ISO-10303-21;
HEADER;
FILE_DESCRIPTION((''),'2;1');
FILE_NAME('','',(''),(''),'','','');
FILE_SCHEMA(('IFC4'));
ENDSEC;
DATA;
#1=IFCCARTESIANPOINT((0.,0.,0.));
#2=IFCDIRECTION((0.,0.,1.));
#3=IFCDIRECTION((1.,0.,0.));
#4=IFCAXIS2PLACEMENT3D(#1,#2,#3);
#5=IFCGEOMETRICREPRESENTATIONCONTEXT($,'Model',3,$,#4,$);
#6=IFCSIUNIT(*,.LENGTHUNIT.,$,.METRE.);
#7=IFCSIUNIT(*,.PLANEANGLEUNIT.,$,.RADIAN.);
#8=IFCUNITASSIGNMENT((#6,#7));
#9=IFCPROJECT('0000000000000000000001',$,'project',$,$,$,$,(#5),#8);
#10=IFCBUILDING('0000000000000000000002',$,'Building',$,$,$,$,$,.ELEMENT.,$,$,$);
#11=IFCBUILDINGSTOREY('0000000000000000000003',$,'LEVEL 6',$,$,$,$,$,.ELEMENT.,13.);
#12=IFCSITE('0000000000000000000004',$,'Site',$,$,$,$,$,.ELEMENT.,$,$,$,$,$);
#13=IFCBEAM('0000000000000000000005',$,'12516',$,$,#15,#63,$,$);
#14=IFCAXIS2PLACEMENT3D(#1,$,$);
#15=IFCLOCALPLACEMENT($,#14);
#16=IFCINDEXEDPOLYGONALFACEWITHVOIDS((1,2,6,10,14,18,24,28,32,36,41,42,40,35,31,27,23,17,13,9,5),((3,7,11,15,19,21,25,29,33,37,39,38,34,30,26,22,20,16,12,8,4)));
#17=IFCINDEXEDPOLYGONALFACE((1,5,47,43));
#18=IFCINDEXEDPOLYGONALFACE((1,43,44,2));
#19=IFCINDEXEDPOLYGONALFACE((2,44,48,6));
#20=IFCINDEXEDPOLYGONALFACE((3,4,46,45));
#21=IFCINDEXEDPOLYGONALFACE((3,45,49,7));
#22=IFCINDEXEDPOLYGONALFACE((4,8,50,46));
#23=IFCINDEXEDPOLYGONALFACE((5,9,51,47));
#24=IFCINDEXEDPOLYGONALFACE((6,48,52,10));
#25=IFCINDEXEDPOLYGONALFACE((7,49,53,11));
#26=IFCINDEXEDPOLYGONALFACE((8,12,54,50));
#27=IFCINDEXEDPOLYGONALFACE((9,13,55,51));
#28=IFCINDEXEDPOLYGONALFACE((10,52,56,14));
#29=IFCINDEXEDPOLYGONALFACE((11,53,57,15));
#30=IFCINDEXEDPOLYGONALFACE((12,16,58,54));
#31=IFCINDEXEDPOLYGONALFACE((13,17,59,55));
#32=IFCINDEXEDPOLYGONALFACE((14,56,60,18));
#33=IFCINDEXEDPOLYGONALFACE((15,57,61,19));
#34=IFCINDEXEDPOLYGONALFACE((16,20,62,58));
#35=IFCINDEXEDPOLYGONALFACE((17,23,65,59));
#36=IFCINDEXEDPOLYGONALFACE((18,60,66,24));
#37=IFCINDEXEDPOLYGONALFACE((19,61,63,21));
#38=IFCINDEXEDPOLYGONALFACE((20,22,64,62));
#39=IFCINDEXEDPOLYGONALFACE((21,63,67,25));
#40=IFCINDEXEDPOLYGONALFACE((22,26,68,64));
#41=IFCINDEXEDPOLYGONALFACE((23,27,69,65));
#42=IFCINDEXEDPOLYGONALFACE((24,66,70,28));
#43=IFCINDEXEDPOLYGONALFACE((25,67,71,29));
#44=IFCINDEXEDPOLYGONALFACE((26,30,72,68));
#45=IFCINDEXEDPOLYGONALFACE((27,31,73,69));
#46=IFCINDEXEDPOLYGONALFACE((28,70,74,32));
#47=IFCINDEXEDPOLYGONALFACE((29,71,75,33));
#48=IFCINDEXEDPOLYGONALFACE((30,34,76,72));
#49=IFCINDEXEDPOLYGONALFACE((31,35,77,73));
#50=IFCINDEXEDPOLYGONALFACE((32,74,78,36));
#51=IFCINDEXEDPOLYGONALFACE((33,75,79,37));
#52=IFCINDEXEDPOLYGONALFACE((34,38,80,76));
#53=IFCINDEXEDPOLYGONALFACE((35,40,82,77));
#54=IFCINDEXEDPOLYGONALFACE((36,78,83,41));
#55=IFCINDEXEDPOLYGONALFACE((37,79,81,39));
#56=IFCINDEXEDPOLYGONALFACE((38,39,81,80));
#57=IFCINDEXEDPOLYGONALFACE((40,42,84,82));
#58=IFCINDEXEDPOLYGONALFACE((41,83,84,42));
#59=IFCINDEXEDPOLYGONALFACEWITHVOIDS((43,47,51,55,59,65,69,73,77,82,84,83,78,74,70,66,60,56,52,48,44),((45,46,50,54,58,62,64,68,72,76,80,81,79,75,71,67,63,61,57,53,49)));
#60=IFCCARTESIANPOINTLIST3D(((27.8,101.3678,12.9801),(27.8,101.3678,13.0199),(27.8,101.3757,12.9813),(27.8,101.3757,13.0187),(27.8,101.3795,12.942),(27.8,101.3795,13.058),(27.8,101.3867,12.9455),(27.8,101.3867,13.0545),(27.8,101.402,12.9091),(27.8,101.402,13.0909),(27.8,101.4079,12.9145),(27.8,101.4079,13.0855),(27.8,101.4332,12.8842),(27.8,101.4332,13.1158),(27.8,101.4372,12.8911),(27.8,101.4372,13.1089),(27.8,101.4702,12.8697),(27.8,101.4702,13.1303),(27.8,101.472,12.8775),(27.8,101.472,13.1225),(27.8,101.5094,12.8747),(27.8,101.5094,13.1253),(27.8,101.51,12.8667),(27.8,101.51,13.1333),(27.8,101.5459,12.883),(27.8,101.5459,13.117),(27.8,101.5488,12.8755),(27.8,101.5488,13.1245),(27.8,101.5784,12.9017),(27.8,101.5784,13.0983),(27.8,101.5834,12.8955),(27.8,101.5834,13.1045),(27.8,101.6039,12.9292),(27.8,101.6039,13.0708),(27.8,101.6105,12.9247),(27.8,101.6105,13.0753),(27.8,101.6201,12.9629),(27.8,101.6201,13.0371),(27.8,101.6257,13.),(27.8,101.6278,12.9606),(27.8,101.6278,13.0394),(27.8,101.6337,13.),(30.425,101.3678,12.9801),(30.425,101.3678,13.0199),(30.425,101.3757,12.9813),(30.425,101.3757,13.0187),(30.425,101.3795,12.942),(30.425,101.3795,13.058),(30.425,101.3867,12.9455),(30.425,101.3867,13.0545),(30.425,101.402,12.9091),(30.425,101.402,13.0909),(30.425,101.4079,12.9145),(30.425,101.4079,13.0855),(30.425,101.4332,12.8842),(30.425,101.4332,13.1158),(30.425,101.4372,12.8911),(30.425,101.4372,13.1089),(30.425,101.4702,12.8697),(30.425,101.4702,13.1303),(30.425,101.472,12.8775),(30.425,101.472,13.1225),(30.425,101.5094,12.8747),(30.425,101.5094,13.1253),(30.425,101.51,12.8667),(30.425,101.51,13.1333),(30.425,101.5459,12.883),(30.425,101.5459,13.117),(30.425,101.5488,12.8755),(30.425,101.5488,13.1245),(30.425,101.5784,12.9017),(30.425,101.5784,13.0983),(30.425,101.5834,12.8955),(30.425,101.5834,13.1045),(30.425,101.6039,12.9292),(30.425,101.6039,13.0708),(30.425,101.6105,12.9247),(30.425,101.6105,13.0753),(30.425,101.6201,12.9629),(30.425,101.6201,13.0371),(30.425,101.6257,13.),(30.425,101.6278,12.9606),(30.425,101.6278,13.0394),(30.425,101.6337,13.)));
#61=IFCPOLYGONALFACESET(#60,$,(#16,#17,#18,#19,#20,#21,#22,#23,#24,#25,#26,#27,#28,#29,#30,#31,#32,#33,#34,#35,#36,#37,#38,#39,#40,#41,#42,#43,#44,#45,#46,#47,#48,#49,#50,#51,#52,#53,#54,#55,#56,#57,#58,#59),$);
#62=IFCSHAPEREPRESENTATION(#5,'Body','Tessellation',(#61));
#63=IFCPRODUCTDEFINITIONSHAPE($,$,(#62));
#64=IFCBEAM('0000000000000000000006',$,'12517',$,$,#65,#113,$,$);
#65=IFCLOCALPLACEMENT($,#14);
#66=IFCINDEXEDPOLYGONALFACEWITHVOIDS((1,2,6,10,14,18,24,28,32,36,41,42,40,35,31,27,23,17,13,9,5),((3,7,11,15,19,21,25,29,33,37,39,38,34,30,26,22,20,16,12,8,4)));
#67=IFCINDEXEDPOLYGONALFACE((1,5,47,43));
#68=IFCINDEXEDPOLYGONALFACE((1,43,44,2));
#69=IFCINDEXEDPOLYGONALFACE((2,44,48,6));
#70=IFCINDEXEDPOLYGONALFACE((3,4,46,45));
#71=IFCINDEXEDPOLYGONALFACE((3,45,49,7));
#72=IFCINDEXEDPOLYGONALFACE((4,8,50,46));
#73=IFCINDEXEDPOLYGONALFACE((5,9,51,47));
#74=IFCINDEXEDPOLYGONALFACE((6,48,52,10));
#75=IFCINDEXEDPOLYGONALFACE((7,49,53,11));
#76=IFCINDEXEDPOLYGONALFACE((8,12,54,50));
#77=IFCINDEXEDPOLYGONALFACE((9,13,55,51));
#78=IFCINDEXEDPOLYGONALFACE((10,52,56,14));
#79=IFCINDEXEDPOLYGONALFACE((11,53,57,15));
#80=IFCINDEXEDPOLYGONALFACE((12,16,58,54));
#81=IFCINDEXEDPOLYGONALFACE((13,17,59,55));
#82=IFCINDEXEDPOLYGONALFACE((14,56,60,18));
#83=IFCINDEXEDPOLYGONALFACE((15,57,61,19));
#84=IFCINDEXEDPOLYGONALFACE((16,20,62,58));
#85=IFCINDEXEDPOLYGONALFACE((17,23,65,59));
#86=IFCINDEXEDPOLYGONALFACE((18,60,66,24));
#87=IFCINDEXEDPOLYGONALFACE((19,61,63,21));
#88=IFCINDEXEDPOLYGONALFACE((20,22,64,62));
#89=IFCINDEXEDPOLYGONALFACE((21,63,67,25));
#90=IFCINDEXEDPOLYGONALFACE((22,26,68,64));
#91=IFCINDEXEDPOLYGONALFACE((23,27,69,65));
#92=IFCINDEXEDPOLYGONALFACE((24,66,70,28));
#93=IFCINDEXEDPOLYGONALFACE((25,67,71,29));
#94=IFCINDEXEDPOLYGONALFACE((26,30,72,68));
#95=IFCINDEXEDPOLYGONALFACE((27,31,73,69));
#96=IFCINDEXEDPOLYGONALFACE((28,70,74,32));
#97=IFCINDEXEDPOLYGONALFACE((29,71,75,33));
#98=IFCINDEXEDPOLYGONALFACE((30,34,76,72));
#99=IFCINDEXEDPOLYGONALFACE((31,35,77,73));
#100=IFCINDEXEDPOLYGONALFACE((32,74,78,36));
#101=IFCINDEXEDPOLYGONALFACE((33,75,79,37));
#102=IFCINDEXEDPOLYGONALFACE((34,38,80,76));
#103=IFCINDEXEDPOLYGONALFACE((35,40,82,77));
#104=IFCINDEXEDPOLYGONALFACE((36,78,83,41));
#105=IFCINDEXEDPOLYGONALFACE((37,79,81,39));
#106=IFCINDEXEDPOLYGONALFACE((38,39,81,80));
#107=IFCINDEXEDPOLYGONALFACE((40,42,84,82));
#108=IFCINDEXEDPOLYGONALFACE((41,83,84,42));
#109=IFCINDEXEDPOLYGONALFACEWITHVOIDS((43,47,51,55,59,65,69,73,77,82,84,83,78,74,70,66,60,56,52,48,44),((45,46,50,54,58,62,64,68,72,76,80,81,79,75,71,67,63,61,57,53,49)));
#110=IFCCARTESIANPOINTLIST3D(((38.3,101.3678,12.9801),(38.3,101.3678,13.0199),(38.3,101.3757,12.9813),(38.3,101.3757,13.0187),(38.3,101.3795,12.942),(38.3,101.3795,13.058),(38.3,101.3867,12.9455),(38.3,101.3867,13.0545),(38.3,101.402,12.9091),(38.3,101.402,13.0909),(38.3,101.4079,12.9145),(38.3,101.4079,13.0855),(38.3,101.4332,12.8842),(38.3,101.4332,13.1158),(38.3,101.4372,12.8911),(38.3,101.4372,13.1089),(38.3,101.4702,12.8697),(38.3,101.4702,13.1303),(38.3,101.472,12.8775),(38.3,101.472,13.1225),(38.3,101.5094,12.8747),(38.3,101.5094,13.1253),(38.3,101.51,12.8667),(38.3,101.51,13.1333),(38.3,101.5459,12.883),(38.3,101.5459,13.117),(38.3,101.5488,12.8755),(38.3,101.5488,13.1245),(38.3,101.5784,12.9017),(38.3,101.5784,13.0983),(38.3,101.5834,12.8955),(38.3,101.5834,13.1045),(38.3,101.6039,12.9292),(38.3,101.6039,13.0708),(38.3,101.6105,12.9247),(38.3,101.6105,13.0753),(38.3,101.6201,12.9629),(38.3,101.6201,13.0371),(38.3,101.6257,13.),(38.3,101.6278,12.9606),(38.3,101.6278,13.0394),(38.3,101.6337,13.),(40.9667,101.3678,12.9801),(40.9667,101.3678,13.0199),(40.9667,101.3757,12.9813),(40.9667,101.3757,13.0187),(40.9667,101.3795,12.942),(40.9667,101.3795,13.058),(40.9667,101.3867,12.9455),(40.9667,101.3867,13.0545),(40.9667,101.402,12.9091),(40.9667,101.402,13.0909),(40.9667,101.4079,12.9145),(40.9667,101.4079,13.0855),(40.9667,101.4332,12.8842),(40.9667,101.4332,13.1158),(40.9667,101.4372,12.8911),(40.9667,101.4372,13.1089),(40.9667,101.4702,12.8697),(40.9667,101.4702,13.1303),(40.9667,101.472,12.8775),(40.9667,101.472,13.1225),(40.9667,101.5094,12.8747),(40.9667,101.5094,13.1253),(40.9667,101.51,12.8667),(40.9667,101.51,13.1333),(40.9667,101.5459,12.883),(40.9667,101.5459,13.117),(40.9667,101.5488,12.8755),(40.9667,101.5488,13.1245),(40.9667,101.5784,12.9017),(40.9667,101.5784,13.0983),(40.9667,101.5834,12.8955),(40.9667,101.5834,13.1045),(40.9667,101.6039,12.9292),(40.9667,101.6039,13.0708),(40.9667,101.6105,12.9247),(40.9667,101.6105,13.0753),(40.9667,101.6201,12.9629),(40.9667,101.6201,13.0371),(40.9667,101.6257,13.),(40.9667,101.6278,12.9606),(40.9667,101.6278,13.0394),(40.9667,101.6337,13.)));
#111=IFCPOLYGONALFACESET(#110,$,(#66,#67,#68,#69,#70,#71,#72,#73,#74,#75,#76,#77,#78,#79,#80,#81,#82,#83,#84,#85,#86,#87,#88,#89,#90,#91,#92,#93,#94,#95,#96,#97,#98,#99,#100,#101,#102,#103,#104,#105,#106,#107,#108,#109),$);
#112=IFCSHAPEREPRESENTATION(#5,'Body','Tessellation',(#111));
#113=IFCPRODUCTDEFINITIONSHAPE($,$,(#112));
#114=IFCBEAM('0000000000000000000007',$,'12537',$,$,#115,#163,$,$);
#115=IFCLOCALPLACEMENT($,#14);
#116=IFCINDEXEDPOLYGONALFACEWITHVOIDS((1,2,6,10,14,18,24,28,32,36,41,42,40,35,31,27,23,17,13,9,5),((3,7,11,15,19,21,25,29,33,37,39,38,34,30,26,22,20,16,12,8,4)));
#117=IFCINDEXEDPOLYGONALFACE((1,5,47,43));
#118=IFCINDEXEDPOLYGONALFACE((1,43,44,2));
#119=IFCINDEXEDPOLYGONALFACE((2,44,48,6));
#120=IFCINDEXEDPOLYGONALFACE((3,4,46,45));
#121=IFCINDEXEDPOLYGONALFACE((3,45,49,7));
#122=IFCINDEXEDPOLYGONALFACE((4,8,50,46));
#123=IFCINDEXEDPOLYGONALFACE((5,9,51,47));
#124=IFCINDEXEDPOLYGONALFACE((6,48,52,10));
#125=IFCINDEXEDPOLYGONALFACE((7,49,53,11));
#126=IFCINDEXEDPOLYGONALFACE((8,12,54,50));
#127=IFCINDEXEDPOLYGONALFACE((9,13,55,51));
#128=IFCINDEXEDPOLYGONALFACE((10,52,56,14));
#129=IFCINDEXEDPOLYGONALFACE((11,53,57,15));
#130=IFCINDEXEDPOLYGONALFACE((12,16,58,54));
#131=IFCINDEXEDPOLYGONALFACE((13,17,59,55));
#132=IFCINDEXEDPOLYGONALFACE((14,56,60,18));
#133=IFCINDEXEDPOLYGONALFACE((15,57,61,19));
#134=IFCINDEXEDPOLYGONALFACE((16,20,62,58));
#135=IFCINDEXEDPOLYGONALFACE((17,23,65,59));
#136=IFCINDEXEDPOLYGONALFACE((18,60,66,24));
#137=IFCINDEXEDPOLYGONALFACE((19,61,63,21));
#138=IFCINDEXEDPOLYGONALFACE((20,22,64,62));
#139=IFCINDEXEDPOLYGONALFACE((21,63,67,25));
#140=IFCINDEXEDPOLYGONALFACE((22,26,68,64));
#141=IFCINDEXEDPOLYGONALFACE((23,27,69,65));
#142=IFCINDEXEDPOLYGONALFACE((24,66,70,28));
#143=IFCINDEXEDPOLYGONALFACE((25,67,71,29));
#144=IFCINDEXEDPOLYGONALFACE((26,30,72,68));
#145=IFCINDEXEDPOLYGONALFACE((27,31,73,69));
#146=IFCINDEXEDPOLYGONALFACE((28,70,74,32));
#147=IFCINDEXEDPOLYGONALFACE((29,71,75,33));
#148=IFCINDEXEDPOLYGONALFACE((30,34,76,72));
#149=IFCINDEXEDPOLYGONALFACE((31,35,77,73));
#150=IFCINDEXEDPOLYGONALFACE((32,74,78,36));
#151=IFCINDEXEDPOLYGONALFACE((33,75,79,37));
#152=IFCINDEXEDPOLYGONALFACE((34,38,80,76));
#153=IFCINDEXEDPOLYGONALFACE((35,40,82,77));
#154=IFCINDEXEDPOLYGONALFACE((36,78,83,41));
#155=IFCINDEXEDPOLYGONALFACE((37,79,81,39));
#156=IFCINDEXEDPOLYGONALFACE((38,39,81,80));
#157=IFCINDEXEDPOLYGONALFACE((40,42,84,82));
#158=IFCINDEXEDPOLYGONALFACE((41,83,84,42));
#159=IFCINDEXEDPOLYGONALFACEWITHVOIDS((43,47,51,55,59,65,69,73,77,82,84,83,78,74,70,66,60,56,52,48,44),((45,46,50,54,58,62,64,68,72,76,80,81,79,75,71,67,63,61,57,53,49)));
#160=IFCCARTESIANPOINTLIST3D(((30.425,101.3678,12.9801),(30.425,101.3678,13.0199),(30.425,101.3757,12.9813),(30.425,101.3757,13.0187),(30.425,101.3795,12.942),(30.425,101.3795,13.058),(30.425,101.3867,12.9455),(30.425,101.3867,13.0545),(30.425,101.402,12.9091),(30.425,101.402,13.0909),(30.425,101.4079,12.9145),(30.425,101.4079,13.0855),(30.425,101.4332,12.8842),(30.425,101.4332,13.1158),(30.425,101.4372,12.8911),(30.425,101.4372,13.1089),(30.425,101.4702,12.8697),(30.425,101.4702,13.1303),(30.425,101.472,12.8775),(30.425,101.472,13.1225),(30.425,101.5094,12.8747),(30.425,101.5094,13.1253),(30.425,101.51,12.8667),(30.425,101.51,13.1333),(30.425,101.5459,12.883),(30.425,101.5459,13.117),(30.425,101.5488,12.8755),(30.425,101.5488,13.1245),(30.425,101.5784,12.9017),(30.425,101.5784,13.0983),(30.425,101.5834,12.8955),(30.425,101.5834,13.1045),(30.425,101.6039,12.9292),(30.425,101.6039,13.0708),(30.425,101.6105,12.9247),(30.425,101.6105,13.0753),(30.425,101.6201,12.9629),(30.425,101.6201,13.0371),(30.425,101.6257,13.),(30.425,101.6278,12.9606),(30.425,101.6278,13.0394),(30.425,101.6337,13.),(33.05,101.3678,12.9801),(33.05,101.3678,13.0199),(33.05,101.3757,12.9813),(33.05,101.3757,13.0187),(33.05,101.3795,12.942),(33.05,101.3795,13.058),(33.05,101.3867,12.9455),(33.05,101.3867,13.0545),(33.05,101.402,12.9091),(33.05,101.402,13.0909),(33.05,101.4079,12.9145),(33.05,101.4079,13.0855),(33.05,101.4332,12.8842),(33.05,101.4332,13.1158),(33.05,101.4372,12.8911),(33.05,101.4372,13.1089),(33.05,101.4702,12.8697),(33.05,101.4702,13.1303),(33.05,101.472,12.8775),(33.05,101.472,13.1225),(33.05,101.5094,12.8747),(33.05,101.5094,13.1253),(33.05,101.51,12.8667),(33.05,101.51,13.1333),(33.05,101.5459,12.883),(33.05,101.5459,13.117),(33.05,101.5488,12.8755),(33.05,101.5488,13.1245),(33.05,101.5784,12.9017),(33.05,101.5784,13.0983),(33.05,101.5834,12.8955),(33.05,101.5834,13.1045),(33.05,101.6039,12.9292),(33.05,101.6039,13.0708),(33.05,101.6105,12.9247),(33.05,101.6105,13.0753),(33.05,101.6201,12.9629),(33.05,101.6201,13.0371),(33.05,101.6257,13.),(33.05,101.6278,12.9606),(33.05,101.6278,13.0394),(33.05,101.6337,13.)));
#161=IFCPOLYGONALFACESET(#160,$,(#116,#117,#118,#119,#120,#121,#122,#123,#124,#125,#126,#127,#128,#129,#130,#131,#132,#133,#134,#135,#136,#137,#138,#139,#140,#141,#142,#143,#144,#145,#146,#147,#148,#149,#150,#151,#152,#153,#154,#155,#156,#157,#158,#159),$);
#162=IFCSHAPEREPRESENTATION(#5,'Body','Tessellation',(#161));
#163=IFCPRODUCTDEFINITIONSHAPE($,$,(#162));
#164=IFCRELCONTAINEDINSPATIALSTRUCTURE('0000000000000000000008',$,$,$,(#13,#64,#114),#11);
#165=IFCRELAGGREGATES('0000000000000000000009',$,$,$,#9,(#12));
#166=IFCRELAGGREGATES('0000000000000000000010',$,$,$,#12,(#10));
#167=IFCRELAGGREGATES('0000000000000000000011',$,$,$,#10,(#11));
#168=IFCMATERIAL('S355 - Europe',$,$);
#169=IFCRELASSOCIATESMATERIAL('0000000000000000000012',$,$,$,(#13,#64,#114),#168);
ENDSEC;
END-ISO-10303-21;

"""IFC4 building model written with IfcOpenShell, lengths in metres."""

from ifc_helpers import new_model, si_unit, frame, origin_with_axes, origin_2d_with_axis, place, context, project, spatial, hollow_circle, extrude, material, material_profile, profile_set, profile_usage, element, save


model = new_model("IFC4")

# Units and contexts
model_context = context("Model", 3, world=origin_with_axes())
ifc_project = project(units=[si_unit("LENGTHUNIT", "METRE"), si_unit("PLANEANGLEUNIT", "RADIAN")], contexts=[model_context])

# Site, building, storey
site = spatial("IfcSite", under=ifc_project, Name="Site", CompositionType="ELEMENT")
building = spatial("IfcBuilding", under=site, Name="Building", CompositionType="ELEMENT")
storey = spatial("IfcBuildingStorey", under=building, Name="LEVEL 6", CompositionType="ELEMENT", Elevation=13.0)

# Shared definitions
ifc_material = material(Name="S355 - Europe")

# Beams
ifc_material_profile_1 = material_profile(ifc_material, hollow_circle(Radius=0.1337, WallThickness=0.008, at=origin_2d_with_axis()))
ifc_profile_set_1 = profile_set([ifc_material_profile_1])
ifc_profile_usage_1 = profile_usage(ifc_profile_set_1, cardinal=10)
beam_1_placement = place(None, frame((27.8, 101.5, 13.0), z_axis=(1.0, 0.0, 0.0), x_axis=(0.0, 1.0, 0.0)))
element("IfcBeam", 1, at=beam_1_placement, inside=storey, material=ifc_profile_usage_1, Name="12516", context=model_context, shape_type="SweptSolid", body=[
    extrude(hollow_circle(Radius=0.1337, WallThickness=0.008, at=origin_2d_with_axis()), origin_with_axes(), (0.0, 0.0, 1.0), 2.625),
])
ifc_material_profile_2 = material_profile(ifc_material, hollow_circle(Radius=0.1337, WallThickness=0.008, at=origin_2d_with_axis()))
ifc_profile_set_2 = profile_set([ifc_material_profile_2])
ifc_profile_usage_2 = profile_usage(ifc_profile_set_2, cardinal=10)
beam_2_placement = place(None, frame((38.3, 101.5, 13.0), z_axis=(1.0, 0.0, 0.0), x_axis=(0.0, 1.0, 0.0)))
element("IfcBeam", 2, at=beam_2_placement, inside=storey, material=ifc_profile_usage_2, Name="12517", context=model_context, shape_type="SweptSolid", body=[
    extrude(hollow_circle(Radius=0.1337, WallThickness=0.008, at=origin_2d_with_axis()), origin_with_axes(), (0.0, 0.0, 1.0), 2.6667),
])
ifc_material_profile_3 = material_profile(ifc_material, hollow_circle(Radius=0.1337, WallThickness=0.008, at=origin_2d_with_axis()))
ifc_profile_set_3 = profile_set([ifc_material_profile_3])
ifc_profile_usage_3 = profile_usage(ifc_profile_set_3, cardinal=10)
beam_3_placement = place(None, frame((30.425, 101.5, 13.0), z_axis=(1.0, 0.0, 0.0), x_axis=(0.0, 1.0, 0.0)))
element("IfcBeam", 3, at=beam_3_placement, inside=storey, material=ifc_profile_usage_3, Name="12537", context=model_context, shape_type="SweptSolid", body=[
    extrude(hollow_circle(Radius=0.1337, WallThickness=0.008, at=origin_2d_with_axis()), origin_with_axes(), (0.0, 0.0, 1.0), 2.625),
])

save(model, "model.ifc")
